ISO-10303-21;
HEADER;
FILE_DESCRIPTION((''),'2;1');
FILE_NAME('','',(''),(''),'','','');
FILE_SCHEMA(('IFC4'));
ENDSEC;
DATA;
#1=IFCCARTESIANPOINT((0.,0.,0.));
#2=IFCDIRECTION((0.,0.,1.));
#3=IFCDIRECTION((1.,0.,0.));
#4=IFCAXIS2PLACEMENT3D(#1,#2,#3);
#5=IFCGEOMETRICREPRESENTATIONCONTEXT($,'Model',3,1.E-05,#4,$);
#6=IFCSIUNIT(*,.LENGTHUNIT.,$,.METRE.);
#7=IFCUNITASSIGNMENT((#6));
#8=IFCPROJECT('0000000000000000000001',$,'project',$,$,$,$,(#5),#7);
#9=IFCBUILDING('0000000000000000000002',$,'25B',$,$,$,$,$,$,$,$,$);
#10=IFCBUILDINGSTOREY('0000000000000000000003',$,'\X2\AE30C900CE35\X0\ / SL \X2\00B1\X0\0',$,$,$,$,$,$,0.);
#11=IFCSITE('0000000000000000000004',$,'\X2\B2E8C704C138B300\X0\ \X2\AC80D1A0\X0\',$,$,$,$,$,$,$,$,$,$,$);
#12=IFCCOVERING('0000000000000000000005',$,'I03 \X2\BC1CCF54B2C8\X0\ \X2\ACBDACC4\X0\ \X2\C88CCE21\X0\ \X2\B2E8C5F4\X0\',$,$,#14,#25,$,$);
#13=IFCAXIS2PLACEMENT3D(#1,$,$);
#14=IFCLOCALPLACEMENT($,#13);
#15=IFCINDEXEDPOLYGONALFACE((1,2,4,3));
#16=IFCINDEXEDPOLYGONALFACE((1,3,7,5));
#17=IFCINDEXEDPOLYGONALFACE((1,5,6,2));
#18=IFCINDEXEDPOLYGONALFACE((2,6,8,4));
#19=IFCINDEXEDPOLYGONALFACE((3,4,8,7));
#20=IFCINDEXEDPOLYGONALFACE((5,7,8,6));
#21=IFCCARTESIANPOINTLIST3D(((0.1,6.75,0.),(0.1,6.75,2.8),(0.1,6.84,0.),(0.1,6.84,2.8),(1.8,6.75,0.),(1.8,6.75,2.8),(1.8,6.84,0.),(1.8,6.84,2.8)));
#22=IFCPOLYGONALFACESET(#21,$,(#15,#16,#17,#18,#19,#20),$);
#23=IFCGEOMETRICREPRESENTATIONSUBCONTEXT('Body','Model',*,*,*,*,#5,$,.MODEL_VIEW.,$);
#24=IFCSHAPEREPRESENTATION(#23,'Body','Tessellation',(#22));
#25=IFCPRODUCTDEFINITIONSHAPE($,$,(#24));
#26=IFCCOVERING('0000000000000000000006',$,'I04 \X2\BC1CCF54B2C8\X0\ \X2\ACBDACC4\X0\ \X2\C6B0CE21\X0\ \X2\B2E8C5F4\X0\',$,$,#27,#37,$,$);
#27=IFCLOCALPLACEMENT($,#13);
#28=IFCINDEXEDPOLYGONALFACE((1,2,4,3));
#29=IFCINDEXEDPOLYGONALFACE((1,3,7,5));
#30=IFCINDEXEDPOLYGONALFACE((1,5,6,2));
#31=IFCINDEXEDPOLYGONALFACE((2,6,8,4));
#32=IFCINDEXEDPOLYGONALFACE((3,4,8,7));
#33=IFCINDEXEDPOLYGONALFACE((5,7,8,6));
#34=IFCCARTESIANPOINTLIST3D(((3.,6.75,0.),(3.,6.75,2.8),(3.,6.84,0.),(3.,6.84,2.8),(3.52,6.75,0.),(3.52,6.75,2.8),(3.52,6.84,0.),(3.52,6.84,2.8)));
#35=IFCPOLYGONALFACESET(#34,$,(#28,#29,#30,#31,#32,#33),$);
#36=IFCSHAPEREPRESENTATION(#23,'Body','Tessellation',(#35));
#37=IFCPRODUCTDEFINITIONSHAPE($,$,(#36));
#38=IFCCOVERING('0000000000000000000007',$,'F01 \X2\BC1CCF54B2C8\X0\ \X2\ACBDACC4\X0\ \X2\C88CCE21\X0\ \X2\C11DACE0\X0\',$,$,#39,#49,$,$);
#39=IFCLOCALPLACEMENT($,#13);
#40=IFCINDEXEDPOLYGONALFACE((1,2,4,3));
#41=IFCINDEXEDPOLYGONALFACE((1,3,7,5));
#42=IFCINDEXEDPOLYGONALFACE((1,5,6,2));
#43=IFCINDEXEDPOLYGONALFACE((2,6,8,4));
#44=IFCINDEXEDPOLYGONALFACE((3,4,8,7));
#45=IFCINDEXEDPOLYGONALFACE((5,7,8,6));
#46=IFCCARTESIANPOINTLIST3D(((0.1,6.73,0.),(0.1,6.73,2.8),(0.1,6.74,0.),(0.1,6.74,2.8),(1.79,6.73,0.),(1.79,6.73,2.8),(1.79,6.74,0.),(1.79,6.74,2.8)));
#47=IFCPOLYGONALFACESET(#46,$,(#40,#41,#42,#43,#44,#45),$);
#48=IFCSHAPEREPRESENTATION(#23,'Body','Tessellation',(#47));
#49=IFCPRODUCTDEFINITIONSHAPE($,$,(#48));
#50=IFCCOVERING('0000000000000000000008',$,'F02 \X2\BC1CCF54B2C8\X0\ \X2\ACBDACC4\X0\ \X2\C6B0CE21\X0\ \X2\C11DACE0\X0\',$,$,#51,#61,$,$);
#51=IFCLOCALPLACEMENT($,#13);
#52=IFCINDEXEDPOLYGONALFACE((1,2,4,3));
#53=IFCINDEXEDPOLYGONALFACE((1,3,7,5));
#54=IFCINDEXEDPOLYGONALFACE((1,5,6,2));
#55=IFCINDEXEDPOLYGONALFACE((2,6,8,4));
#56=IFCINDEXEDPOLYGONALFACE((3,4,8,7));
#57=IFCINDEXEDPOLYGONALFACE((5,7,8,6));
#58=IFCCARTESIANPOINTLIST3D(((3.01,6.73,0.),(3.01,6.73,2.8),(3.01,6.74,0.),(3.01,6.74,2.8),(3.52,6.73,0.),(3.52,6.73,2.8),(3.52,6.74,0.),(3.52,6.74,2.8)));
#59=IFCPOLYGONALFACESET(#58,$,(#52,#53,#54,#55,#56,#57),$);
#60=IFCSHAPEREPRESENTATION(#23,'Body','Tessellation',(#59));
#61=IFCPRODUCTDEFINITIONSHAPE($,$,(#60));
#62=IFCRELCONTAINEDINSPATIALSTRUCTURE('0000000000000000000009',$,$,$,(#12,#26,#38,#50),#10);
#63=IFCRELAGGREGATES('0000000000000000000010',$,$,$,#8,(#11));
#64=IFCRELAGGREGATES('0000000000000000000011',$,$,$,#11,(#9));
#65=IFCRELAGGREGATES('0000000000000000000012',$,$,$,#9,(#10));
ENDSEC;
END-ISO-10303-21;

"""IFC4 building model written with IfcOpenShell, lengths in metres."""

from ifc_helpers import new_model, si_unit, origin, origin_with_axes, place, context, subcontext, project, spatial, polyline, outline, extrude, element, save


model = new_model("IFC4")

# Units and contexts
model_context = context("Model", 3, precision=1e-05, world=origin_with_axes())
body_context = subcontext(model_context, "Body", "Model", "MODEL_VIEW")
ifc_project = project(units=[si_unit("LENGTHUNIT", "METRE")], contexts=[model_context])

# Site, building, storey
site = spatial("IfcSite", under=ifc_project, Name="단위세대 검토")
building = spatial("IfcBuilding", under=site, Name="25B")
storey = spatial("IfcBuildingStorey", under=building, Name="기준층 / SL ±0", Elevation=0.0)

# Coverings
covering_1_placement = place(None, origin_with_axes())
element("IfcCovering", 1, at=covering_1_placement, inside=storey, Name="I03 발코니 경계 좌측 단열", context=body_context, shape_type="SweptSolid", body=[
    extrude(outline(polyline([(1.8, 6.75), (1.8, 6.84), (0.1, 6.84), (0.1, 6.75), (1.8, 6.75)])), origin(), (0.0, 0.0, 1.0), 2.8),
])
covering_2_placement = place(None, origin_with_axes())
element("IfcCovering", 2, at=covering_2_placement, inside=storey, Name="I04 발코니 경계 우측 단열", context=body_context, shape_type="SweptSolid", body=[
    extrude(outline(polyline([(3.52, 6.75), (3.52, 6.84), (3.0, 6.84), (3.0, 6.75), (3.52, 6.75)])), origin(), (0.0, 0.0, 1.0), 2.8),
])
covering_3_placement = place(None, origin_with_axes())
element("IfcCovering", 3, at=covering_3_placement, inside=storey, Name="F01 발코니 경계 좌측 석고", context=body_context, shape_type="SweptSolid", body=[
    extrude(outline(polyline([(1.79, 6.73), (1.79, 6.74), (0.1, 6.74), (0.1, 6.73), (1.79, 6.73)])), origin(), (0.0, 0.0, 1.0), 2.8),
])
covering_4_placement = place(None, origin_with_axes())
element("IfcCovering", 4, at=covering_4_placement, inside=storey, Name="F02 발코니 경계 우측 석고", context=body_context, shape_type="SweptSolid", body=[
    extrude(outline(polyline([(3.52, 6.73), (3.52, 6.74), (3.01, 6.74), (3.01, 6.73), (3.52, 6.73)])), origin(), (0.0, 0.0, 1.0), 2.8),
])

save(model, "model.ifc")
